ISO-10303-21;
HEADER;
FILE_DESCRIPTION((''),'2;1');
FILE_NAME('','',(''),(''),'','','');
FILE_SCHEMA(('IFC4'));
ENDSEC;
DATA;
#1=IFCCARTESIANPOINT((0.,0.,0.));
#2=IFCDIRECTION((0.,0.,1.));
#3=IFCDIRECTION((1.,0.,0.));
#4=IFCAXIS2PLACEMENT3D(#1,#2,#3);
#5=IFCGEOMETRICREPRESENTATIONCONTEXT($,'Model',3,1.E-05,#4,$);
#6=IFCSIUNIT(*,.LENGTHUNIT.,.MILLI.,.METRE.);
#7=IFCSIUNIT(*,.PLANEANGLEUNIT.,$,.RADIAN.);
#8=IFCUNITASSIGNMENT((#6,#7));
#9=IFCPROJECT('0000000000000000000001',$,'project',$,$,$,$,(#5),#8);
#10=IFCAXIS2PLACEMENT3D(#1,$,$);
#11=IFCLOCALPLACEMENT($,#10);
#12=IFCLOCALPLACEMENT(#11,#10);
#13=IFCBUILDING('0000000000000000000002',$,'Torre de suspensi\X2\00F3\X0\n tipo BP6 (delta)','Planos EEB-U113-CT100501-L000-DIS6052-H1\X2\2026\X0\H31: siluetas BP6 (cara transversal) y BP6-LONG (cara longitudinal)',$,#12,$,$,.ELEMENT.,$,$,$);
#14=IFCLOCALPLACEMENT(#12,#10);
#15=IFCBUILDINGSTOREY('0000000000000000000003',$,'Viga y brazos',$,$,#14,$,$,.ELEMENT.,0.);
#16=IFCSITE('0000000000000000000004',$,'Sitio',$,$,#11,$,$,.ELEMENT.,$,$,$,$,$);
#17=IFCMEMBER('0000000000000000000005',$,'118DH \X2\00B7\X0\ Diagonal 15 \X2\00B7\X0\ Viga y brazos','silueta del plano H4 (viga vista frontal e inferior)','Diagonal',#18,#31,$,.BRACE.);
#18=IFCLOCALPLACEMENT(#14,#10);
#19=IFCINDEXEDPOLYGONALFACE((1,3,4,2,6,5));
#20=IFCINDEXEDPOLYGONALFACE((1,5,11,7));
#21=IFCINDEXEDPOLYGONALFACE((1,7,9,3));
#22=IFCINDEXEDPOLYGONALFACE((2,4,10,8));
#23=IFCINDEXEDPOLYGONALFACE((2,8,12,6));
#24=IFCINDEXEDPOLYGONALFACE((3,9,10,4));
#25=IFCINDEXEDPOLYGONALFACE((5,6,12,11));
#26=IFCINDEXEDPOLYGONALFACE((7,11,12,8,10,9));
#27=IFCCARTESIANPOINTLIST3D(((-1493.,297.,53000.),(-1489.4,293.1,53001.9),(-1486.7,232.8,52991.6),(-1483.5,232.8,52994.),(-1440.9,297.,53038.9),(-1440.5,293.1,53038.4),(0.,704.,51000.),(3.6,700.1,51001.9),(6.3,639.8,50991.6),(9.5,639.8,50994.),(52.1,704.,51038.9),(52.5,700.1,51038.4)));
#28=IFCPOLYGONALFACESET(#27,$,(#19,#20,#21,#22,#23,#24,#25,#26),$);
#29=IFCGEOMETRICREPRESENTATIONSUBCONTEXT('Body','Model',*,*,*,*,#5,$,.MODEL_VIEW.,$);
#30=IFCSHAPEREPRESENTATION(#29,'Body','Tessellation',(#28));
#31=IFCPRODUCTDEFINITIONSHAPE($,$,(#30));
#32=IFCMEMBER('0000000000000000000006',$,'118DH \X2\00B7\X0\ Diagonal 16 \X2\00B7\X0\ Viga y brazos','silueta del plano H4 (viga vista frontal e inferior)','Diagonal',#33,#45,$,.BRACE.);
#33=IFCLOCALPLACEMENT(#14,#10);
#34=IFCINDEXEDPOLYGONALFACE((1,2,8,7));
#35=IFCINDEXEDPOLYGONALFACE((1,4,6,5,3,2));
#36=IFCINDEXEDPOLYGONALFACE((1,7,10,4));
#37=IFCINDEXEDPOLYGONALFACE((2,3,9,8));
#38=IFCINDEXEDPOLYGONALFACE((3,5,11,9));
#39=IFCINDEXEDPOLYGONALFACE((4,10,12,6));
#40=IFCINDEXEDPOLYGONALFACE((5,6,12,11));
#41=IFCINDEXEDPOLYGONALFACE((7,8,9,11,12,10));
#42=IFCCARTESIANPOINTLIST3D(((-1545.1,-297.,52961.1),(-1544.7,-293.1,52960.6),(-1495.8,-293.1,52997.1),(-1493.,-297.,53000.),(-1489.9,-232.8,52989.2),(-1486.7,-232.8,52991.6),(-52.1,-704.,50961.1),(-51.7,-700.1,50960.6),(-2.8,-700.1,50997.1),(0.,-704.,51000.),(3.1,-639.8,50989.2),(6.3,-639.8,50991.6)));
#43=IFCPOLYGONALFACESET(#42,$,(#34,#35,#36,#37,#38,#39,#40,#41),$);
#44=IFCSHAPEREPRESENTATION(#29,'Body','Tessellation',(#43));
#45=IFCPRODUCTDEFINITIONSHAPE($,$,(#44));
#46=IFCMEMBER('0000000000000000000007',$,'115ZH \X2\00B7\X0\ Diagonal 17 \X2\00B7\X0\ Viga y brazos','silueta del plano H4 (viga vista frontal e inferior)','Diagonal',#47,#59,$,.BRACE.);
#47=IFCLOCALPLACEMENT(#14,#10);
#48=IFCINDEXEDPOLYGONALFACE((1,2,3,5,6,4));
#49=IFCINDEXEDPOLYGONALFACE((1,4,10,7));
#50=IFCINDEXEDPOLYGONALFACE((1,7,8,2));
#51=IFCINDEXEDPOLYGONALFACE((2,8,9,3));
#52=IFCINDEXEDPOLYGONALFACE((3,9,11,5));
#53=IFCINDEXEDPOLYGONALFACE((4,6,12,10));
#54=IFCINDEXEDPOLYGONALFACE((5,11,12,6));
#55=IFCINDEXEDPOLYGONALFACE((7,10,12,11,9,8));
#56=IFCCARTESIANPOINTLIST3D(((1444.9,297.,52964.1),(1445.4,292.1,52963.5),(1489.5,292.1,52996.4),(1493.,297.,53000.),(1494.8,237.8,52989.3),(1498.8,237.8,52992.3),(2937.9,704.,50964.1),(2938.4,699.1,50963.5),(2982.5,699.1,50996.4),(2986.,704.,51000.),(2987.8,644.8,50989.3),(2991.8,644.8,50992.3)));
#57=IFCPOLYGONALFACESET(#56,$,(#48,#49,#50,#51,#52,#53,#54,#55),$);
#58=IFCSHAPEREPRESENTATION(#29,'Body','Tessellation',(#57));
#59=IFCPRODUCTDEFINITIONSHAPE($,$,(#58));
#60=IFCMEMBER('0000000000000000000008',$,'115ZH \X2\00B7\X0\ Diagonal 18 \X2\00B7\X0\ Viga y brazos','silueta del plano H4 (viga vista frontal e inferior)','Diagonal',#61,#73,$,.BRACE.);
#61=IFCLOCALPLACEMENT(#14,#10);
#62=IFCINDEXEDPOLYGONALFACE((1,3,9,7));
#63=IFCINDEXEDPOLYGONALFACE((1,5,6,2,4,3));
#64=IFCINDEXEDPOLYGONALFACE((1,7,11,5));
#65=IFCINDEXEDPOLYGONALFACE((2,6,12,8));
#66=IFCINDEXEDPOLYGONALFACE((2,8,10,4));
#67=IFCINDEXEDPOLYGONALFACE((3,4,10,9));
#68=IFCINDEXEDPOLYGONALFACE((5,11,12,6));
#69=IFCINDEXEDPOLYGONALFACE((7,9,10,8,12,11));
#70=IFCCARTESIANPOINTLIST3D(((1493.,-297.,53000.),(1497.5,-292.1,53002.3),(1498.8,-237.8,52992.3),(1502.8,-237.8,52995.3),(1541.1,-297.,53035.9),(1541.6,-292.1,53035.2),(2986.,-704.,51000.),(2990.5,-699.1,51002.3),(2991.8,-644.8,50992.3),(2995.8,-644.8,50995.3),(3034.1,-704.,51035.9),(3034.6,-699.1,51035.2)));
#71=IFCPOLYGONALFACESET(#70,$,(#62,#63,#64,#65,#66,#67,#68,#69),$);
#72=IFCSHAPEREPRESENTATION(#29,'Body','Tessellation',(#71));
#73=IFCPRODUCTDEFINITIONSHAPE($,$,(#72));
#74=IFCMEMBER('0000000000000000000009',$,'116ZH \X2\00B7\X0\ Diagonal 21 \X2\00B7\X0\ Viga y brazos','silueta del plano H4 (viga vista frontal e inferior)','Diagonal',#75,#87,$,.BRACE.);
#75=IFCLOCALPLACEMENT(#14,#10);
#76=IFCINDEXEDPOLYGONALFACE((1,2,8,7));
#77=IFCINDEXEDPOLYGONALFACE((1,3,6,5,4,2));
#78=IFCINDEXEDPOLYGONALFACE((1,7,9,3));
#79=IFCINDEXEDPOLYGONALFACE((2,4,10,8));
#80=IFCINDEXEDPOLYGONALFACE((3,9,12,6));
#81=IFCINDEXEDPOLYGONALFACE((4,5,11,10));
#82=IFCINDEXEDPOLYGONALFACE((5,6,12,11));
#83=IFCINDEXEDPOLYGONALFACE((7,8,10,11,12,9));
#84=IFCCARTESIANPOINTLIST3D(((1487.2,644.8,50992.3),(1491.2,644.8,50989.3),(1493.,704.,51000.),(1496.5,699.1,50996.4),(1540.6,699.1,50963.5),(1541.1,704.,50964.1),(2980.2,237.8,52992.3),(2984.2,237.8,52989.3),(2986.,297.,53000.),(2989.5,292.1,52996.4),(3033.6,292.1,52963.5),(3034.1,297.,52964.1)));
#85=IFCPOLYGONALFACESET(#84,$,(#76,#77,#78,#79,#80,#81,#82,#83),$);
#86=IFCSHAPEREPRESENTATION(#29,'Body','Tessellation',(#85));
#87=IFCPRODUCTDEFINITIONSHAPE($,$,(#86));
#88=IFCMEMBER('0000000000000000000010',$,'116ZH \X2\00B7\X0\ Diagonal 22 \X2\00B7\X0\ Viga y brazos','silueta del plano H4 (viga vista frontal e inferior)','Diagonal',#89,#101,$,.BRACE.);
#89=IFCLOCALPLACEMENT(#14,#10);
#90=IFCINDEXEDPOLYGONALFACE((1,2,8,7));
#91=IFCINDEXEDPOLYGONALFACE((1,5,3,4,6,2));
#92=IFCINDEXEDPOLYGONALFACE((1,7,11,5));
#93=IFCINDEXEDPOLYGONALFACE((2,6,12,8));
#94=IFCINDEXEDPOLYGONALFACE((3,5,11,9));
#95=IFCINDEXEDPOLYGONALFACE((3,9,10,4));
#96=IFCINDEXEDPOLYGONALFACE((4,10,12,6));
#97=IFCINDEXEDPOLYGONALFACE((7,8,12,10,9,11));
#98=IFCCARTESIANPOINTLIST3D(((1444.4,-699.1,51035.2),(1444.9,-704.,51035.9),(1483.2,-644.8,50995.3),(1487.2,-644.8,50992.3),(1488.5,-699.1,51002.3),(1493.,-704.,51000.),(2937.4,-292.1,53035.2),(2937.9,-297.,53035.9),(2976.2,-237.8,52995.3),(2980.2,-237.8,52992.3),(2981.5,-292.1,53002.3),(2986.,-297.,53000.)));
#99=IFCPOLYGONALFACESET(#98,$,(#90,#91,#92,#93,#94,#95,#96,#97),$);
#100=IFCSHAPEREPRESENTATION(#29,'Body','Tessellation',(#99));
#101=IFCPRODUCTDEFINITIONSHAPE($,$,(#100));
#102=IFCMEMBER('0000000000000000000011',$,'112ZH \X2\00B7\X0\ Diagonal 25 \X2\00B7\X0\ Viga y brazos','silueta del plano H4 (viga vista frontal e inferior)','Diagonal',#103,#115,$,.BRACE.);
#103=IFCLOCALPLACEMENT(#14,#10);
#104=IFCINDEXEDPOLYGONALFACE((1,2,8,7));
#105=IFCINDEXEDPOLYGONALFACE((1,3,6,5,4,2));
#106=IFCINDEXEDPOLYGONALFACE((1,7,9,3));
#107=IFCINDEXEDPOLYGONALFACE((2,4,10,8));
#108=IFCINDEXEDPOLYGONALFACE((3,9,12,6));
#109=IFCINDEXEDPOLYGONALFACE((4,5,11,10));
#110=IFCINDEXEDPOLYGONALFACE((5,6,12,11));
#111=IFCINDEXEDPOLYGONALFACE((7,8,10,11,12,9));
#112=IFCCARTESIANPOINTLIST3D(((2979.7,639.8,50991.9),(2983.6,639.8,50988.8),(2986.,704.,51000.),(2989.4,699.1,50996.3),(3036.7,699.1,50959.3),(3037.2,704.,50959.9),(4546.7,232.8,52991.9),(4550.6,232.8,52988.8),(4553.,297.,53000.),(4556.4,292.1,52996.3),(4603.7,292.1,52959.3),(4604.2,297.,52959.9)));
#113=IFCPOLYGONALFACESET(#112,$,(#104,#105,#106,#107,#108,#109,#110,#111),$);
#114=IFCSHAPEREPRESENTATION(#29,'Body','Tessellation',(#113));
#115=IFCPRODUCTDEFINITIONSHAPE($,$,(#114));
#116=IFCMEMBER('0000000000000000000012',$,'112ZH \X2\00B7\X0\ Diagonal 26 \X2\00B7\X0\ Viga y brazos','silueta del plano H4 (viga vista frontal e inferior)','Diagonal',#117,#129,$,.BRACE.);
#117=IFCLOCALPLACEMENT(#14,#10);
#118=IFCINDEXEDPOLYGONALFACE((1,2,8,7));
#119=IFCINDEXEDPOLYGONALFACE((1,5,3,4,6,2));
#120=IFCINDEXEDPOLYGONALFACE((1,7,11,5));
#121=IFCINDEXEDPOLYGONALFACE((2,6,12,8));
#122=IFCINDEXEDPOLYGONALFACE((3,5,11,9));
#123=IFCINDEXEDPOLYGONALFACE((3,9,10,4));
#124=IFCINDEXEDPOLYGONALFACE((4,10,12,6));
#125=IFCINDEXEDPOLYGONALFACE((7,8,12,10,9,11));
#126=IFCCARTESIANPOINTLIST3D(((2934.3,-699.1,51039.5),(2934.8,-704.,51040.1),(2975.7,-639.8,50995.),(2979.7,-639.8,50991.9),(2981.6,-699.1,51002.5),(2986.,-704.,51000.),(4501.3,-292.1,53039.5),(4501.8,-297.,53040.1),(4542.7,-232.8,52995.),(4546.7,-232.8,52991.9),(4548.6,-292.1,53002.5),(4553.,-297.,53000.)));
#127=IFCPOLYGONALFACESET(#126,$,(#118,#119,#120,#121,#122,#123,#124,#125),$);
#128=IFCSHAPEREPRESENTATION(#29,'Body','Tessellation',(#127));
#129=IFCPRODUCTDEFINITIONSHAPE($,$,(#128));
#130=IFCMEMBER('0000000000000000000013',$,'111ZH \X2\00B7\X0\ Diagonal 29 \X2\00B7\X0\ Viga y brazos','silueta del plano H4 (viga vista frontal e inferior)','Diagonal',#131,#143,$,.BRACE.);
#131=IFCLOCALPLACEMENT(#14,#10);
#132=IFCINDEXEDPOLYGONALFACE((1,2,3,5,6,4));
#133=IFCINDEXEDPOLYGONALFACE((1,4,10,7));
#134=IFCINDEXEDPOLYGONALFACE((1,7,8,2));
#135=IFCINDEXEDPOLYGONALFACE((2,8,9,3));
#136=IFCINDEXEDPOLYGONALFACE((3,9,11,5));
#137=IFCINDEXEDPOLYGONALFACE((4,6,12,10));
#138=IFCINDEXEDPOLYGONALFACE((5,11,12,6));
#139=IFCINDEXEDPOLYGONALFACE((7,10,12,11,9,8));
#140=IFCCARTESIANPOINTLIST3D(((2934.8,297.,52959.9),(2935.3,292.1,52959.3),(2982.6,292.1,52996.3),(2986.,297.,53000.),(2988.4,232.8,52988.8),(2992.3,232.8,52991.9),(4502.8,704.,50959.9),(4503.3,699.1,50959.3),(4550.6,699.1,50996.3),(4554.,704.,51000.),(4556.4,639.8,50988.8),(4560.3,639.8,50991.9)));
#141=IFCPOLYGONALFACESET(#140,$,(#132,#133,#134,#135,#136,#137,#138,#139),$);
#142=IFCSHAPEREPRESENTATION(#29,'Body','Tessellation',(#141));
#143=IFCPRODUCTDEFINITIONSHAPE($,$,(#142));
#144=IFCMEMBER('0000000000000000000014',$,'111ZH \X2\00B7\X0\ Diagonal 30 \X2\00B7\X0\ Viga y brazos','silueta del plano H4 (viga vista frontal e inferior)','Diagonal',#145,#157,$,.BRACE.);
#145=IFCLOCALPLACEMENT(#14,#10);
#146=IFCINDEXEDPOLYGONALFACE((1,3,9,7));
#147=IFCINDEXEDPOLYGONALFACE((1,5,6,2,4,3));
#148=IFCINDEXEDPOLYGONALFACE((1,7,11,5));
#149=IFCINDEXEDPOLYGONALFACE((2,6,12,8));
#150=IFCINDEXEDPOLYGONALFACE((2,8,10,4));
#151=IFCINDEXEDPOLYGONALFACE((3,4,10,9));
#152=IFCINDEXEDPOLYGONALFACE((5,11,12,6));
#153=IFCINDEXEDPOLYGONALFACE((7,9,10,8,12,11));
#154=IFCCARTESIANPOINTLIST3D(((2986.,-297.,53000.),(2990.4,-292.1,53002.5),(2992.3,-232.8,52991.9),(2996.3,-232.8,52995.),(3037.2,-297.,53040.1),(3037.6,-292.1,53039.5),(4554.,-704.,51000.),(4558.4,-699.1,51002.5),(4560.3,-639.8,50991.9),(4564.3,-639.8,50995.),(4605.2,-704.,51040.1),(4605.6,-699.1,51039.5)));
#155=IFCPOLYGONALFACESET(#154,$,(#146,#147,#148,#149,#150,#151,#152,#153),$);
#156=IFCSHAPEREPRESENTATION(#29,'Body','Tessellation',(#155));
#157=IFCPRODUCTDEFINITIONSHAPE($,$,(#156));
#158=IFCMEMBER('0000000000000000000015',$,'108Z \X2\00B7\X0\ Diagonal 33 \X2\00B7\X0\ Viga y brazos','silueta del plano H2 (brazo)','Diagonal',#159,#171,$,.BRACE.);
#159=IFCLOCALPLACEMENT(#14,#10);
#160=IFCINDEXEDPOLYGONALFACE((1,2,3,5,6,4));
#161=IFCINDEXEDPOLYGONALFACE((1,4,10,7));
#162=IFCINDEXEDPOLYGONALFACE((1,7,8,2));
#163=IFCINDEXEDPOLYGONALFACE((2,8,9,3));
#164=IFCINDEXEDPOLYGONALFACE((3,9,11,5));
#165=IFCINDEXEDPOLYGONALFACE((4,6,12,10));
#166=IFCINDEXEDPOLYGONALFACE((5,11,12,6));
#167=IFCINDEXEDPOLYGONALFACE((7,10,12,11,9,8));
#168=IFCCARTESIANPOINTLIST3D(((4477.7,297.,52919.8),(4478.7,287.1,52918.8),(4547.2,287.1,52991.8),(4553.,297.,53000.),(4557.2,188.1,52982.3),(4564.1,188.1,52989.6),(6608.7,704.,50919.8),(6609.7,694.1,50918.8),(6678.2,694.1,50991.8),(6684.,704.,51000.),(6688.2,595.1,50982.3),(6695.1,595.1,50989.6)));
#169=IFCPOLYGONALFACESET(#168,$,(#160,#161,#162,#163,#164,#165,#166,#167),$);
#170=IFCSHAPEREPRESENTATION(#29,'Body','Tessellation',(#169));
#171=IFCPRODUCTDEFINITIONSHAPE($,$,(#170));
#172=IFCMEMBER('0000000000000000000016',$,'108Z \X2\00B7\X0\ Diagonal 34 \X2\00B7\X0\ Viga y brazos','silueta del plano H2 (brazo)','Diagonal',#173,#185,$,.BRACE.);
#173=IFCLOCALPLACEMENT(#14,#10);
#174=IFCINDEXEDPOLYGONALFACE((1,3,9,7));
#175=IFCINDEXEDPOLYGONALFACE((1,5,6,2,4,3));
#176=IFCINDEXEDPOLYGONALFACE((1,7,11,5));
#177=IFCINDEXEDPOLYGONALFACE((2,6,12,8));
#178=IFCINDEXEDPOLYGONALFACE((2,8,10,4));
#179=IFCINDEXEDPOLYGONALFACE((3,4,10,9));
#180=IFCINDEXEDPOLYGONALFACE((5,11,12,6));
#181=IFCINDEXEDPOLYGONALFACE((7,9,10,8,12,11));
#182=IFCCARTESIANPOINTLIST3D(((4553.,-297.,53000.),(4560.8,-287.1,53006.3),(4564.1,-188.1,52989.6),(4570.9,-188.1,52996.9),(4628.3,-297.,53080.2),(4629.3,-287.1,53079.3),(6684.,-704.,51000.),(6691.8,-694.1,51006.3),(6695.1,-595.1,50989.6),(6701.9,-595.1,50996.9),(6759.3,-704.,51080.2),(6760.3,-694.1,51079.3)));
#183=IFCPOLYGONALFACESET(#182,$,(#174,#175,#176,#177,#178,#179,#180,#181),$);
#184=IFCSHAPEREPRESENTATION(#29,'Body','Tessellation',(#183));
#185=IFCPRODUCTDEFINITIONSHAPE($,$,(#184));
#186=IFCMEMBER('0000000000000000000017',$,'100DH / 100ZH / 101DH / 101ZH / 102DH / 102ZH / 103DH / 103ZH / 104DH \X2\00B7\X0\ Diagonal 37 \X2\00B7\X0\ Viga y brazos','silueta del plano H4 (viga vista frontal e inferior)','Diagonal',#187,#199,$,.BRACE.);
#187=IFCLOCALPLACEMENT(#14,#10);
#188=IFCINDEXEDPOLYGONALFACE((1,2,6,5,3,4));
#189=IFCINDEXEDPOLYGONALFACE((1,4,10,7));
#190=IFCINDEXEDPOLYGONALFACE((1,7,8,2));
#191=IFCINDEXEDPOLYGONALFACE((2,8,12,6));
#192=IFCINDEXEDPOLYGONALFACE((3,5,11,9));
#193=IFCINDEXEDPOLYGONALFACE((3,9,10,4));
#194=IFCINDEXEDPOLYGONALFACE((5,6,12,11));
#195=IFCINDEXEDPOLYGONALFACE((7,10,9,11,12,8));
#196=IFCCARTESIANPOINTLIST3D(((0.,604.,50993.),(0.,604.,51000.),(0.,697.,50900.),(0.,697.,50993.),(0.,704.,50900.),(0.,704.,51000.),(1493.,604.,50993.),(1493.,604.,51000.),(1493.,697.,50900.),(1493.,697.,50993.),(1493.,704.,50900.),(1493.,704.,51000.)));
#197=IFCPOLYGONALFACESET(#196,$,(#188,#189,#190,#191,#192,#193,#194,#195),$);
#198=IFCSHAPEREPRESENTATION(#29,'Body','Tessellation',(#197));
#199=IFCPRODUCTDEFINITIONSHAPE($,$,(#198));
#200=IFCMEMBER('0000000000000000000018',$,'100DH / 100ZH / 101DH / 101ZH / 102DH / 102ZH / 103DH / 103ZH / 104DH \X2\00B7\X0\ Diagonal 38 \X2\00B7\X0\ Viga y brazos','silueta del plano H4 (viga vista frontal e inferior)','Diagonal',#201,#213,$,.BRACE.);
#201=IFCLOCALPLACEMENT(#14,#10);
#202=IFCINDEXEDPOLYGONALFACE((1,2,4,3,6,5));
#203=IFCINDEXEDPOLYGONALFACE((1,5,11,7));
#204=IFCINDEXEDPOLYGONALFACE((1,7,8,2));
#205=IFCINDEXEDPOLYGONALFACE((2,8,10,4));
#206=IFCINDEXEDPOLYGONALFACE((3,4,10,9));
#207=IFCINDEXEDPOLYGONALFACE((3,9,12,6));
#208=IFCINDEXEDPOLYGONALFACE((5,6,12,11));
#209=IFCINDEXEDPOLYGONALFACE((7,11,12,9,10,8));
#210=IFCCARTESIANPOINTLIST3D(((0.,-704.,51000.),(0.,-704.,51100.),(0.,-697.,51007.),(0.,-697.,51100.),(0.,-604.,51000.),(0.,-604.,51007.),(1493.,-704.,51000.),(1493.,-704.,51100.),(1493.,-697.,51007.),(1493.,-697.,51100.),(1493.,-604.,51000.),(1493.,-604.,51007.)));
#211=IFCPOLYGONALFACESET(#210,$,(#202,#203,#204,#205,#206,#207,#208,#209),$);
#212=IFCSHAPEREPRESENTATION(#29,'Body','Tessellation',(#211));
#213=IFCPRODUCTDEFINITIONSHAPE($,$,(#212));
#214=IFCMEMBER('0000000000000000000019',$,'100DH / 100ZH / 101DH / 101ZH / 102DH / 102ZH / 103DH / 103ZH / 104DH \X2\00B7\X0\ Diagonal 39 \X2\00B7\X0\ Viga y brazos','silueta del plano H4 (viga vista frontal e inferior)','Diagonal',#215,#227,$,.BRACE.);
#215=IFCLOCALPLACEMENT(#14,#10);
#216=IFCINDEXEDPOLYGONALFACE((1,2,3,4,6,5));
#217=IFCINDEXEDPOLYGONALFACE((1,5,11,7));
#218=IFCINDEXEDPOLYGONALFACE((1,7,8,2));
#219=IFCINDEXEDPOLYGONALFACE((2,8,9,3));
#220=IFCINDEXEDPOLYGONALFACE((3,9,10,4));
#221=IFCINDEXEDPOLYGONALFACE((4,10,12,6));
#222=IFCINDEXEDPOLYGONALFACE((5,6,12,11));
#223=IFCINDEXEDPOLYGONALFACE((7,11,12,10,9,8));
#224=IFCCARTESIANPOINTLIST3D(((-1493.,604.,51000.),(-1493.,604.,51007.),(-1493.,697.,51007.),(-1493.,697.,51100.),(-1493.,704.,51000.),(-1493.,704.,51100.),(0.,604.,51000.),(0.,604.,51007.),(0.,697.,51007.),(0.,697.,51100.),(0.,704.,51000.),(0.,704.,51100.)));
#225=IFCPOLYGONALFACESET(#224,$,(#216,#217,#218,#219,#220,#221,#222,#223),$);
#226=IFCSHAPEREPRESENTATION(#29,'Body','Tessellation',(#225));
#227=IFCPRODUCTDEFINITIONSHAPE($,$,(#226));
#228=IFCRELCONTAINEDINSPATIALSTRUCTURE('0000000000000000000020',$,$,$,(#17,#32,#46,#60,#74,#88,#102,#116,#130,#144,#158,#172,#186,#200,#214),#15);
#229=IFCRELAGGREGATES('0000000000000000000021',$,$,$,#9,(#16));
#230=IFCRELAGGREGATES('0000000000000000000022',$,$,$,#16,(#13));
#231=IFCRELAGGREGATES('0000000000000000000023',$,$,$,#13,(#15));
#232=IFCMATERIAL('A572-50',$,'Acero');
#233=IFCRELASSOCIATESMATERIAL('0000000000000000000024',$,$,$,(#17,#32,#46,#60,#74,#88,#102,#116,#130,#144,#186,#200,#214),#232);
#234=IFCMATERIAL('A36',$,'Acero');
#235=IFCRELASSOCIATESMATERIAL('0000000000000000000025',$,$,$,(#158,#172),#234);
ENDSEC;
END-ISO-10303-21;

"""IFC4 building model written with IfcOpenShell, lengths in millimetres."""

from ifc_helpers import new_model, si_unit, frame, frame_2d, origin, origin_with_axes, place, context, subcontext, project, spatial, l_section, extrude, material, element, save


model = new_model("IFC4")

# Units and contexts
model_context = context("Model", 3, precision=1e-05, world=origin_with_axes())
body_context = subcontext(model_context, "Body", "Model", "MODEL_VIEW")
ifc_project = project(units=[si_unit("LENGTHUNIT", "METRE", prefix="MILLI"), si_unit("PLANEANGLEUNIT", "RADIAN")], contexts=[model_context])

# Site, building, storey
site_placement = place(None, origin())
site = spatial("IfcSite", under=ifc_project, at=site_placement, Name="Sitio", CompositionType="ELEMENT")
building_placement = place(site_placement, origin())
building = spatial("IfcBuilding", under=site, at=building_placement, Name="Torre de suspensión tipo BP6 (delta)", Description="Planos EEB-U113-CT100501-L000-DIS6052-H1…H31: siluetas BP6 (cara transversal) y BP6-LONG (cara longitudinal)", CompositionType="ELEMENT")
storey_placement = place(building_placement, origin())
storey = spatial("IfcBuildingStorey", under=building, at=storey_placement, Name="Viga y brazos", CompositionType="ELEMENT", Elevation=0.0)

# Members
ifc_material_1 = material(Name="A572-50", Category="Acero")
for number, where, z_axis, x_axis, name in (
    (1, (0.0, 704.0, 51000.0), (-0.590405, -0.160948, 0.790897), (0.096279, -0.986963, -0.128974), "118DH · Diagonal 15 · Viga y brazos"),
    (2, (0.0, -704.0, 51000.0), (-0.590405, 0.160948, 0.790897), (0.096279, 0.986963, -0.128974), "118DH · Diagonal 16 · Viga y brazos"),
):
    element("IfcMember", number, at=place(storey_placement, frame(where, z_axis=z_axis, x_axis=x_axis)), inside=storey, material=ifc_material_1, Name=name, Description="silueta del plano H4 (viga vista frontal e inferior)", ObjectType="Diagonal", PredefinedType="BRACE", context=body_context, shape_type="SweptSolid", body=[
        extrude(l_section(Depth=65.0, Width=65.0, Thickness=4.0, at=frame_2d((32.5, 32.5))), None, (0.0, 0.0, 1.0), 2528.8),
    ])
for number, where, z_axis, x_axis, name in (
    (3, (1493.0, 297.0, 53000.0), (0.590405, 0.160948, -0.790897), (0.096279, -0.986963, -0.128974), "115ZH · Diagonal 17 · Viga y brazos"),
    (4, (1493.0, -297.0, 53000.0), (0.590405, -0.160948, -0.790897), (0.096279, 0.986963, -0.128974), "115ZH · Diagonal 18 · Viga y brazos"),
    (5, (1493.0, 704.0, 51000.0), (0.590405, -0.160948, 0.790897), (-0.096279, -0.986963, -0.128974), "116ZH · Diagonal 21 · Viga y brazos"),
    (6, (1493.0, -704.0, 51000.0), (0.590405, 0.160948, 0.790897), (-0.096279, 0.986963, -0.128974), "116ZH · Diagonal 22 · Viga y brazos"),
):
    element("IfcMember", number, at=place(storey_placement, frame(where, z_axis=z_axis, x_axis=x_axis)), inside=storey, material=ifc_material_1, Name=name, Description="silueta del plano H4 (viga vista frontal e inferior)", ObjectType="Diagonal", PredefinedType="BRACE", context=body_context, shape_type="SweptSolid", body=[
        extrude(l_section(Depth=60.0, Width=60.0, Thickness=5.0, at=frame_2d((30.0, 30.0))), None, (0.0, 0.0, 1.0), 2528.8),
    ])
for number, where, z_axis, x_axis, name in (
    (7, (2986.0, 704.0, 51000.0), (0.60898, -0.158171, 0.777255), (-0.097551, -0.987412, -0.124507), "112ZH · Diagonal 25 · Viga y brazos"),
    (8, (2986.0, -704.0, 51000.0), (0.60898, 0.158171, 0.777255), (-0.097551, 0.987412, -0.124507), "112ZH · Diagonal 26 · Viga y brazos"),
):
    element("IfcMember", number, at=place(storey_placement, frame(where, z_axis=z_axis, x_axis=x_axis)), inside=storey, material=ifc_material_1, Name=name, Description="silueta del plano H4 (viga vista frontal e inferior)", ObjectType="Diagonal", PredefinedType="BRACE", context=body_context, shape_type="SweptSolid", body=[
        extrude(l_section(Depth=65.0, Width=65.0, Thickness=5.0, at=frame_2d((32.5, 32.5))), None, (0.0, 0.0, 1.0), 2573.2),
    ])
for number, where, z_axis, x_axis, name in (
    (9, (2986.0, 297.0, 53000.0), (0.609224, 0.158134, -0.777071), (0.097567, -0.987418, -0.124447), "111ZH · Diagonal 29 · Viga y brazos"),
    (10, (2986.0, -297.0, 53000.0), (0.609224, -0.158134, -0.777071), (0.097567, 0.987418, -0.124447), "111ZH · Diagonal 30 · Viga y brazos"),
):
    element("IfcMember", number, at=place(storey_placement, frame(where, z_axis=z_axis, x_axis=x_axis)), inside=storey, material=ifc_material_1, Name=name, Description="silueta del plano H4 (viga vista frontal e inferior)", ObjectType="Diagonal", PredefinedType="BRACE", context=body_context, shape_type="SweptSolid", body=[
        extrude(l_section(Depth=65.0, Width=65.0, Thickness=5.0, at=frame_2d((32.5, 32.5))), None, (0.0, 0.0, 1.0), 2573.8),
    ])
ifc_material_2 = material(Name="A36", Category="Acero")
for number, where, z_axis, x_axis, name in (
    (11, (4553.0, 297.0, 53000.0), (0.722194, 0.137932, -0.677798), (0.100575, -0.990442, -0.094392), "108Z · Diagonal 33 · Viga y brazos"),
    (12, (4553.0, -297.0, 53000.0), (0.722194, -0.137932, -0.677798), (0.100575, 0.990442, -0.094392), "108Z · Diagonal 34 · Viga y brazos"),
):
    element("IfcMember", number, at=place(storey_placement, frame(where, z_axis=z_axis, x_axis=x_axis)), inside=storey, material=ifc_material_2, Name=name, Description="silueta del plano H2 (brazo)", ObjectType="Diagonal", PredefinedType="BRACE", context=body_context, shape_type="SweptSolid", body=[
        extrude(l_section(Depth=110.0, Width=110.0, Thickness=10.0, at=frame_2d((55.0, 55.0))), None, (0.0, 0.0, 1.0), 2950.7),
    ])
for number, where, z_axis, x_axis, name in (
    (13, (0.0, 704.0, 51000.0), (1.0, 0.0, 0.0), (0.0, -1.0, 0.0), "100DH / 100ZH / 101DH / 101ZH / 102DH / 102ZH / 103DH / 103ZH / 104DH · Diagonal 37 · Viga y brazos"),
    (14, (0.0, -704.0, 51000.0), (1.0, 0.0, 0.0), (0.0, 1.0, 0.0), "100DH / 100ZH / 101DH / 101ZH / 102DH / 102ZH / 103DH / 103ZH / 104DH · Diagonal 38 · Viga y brazos"),
    (15, (0.0, 704.0, 51000.0), (-1.0, 0.0, 0.0), (0.0, -1.0, 0.0), "100DH / 100ZH / 101DH / 101ZH / 102DH / 102ZH / 103DH / 103ZH / 104DH · Diagonal 39 · Viga y brazos"),
):
    element("IfcMember", number, at=place(storey_placement, frame(where, z_axis=z_axis, x_axis=x_axis)), inside=storey, material=ifc_material_1, Name=name, Description="silueta del plano H4 (viga vista frontal e inferior)", ObjectType="Diagonal", PredefinedType="BRACE", context=body_context, shape_type="SweptSolid", body=[
        extrude(l_section(Depth=100.0, Width=100.0, Thickness=7.0, at=frame_2d((50.0, 50.0))), None, (0.0, 0.0, 1.0), 1493.0),
    ])

save(model, "model.ifc")
